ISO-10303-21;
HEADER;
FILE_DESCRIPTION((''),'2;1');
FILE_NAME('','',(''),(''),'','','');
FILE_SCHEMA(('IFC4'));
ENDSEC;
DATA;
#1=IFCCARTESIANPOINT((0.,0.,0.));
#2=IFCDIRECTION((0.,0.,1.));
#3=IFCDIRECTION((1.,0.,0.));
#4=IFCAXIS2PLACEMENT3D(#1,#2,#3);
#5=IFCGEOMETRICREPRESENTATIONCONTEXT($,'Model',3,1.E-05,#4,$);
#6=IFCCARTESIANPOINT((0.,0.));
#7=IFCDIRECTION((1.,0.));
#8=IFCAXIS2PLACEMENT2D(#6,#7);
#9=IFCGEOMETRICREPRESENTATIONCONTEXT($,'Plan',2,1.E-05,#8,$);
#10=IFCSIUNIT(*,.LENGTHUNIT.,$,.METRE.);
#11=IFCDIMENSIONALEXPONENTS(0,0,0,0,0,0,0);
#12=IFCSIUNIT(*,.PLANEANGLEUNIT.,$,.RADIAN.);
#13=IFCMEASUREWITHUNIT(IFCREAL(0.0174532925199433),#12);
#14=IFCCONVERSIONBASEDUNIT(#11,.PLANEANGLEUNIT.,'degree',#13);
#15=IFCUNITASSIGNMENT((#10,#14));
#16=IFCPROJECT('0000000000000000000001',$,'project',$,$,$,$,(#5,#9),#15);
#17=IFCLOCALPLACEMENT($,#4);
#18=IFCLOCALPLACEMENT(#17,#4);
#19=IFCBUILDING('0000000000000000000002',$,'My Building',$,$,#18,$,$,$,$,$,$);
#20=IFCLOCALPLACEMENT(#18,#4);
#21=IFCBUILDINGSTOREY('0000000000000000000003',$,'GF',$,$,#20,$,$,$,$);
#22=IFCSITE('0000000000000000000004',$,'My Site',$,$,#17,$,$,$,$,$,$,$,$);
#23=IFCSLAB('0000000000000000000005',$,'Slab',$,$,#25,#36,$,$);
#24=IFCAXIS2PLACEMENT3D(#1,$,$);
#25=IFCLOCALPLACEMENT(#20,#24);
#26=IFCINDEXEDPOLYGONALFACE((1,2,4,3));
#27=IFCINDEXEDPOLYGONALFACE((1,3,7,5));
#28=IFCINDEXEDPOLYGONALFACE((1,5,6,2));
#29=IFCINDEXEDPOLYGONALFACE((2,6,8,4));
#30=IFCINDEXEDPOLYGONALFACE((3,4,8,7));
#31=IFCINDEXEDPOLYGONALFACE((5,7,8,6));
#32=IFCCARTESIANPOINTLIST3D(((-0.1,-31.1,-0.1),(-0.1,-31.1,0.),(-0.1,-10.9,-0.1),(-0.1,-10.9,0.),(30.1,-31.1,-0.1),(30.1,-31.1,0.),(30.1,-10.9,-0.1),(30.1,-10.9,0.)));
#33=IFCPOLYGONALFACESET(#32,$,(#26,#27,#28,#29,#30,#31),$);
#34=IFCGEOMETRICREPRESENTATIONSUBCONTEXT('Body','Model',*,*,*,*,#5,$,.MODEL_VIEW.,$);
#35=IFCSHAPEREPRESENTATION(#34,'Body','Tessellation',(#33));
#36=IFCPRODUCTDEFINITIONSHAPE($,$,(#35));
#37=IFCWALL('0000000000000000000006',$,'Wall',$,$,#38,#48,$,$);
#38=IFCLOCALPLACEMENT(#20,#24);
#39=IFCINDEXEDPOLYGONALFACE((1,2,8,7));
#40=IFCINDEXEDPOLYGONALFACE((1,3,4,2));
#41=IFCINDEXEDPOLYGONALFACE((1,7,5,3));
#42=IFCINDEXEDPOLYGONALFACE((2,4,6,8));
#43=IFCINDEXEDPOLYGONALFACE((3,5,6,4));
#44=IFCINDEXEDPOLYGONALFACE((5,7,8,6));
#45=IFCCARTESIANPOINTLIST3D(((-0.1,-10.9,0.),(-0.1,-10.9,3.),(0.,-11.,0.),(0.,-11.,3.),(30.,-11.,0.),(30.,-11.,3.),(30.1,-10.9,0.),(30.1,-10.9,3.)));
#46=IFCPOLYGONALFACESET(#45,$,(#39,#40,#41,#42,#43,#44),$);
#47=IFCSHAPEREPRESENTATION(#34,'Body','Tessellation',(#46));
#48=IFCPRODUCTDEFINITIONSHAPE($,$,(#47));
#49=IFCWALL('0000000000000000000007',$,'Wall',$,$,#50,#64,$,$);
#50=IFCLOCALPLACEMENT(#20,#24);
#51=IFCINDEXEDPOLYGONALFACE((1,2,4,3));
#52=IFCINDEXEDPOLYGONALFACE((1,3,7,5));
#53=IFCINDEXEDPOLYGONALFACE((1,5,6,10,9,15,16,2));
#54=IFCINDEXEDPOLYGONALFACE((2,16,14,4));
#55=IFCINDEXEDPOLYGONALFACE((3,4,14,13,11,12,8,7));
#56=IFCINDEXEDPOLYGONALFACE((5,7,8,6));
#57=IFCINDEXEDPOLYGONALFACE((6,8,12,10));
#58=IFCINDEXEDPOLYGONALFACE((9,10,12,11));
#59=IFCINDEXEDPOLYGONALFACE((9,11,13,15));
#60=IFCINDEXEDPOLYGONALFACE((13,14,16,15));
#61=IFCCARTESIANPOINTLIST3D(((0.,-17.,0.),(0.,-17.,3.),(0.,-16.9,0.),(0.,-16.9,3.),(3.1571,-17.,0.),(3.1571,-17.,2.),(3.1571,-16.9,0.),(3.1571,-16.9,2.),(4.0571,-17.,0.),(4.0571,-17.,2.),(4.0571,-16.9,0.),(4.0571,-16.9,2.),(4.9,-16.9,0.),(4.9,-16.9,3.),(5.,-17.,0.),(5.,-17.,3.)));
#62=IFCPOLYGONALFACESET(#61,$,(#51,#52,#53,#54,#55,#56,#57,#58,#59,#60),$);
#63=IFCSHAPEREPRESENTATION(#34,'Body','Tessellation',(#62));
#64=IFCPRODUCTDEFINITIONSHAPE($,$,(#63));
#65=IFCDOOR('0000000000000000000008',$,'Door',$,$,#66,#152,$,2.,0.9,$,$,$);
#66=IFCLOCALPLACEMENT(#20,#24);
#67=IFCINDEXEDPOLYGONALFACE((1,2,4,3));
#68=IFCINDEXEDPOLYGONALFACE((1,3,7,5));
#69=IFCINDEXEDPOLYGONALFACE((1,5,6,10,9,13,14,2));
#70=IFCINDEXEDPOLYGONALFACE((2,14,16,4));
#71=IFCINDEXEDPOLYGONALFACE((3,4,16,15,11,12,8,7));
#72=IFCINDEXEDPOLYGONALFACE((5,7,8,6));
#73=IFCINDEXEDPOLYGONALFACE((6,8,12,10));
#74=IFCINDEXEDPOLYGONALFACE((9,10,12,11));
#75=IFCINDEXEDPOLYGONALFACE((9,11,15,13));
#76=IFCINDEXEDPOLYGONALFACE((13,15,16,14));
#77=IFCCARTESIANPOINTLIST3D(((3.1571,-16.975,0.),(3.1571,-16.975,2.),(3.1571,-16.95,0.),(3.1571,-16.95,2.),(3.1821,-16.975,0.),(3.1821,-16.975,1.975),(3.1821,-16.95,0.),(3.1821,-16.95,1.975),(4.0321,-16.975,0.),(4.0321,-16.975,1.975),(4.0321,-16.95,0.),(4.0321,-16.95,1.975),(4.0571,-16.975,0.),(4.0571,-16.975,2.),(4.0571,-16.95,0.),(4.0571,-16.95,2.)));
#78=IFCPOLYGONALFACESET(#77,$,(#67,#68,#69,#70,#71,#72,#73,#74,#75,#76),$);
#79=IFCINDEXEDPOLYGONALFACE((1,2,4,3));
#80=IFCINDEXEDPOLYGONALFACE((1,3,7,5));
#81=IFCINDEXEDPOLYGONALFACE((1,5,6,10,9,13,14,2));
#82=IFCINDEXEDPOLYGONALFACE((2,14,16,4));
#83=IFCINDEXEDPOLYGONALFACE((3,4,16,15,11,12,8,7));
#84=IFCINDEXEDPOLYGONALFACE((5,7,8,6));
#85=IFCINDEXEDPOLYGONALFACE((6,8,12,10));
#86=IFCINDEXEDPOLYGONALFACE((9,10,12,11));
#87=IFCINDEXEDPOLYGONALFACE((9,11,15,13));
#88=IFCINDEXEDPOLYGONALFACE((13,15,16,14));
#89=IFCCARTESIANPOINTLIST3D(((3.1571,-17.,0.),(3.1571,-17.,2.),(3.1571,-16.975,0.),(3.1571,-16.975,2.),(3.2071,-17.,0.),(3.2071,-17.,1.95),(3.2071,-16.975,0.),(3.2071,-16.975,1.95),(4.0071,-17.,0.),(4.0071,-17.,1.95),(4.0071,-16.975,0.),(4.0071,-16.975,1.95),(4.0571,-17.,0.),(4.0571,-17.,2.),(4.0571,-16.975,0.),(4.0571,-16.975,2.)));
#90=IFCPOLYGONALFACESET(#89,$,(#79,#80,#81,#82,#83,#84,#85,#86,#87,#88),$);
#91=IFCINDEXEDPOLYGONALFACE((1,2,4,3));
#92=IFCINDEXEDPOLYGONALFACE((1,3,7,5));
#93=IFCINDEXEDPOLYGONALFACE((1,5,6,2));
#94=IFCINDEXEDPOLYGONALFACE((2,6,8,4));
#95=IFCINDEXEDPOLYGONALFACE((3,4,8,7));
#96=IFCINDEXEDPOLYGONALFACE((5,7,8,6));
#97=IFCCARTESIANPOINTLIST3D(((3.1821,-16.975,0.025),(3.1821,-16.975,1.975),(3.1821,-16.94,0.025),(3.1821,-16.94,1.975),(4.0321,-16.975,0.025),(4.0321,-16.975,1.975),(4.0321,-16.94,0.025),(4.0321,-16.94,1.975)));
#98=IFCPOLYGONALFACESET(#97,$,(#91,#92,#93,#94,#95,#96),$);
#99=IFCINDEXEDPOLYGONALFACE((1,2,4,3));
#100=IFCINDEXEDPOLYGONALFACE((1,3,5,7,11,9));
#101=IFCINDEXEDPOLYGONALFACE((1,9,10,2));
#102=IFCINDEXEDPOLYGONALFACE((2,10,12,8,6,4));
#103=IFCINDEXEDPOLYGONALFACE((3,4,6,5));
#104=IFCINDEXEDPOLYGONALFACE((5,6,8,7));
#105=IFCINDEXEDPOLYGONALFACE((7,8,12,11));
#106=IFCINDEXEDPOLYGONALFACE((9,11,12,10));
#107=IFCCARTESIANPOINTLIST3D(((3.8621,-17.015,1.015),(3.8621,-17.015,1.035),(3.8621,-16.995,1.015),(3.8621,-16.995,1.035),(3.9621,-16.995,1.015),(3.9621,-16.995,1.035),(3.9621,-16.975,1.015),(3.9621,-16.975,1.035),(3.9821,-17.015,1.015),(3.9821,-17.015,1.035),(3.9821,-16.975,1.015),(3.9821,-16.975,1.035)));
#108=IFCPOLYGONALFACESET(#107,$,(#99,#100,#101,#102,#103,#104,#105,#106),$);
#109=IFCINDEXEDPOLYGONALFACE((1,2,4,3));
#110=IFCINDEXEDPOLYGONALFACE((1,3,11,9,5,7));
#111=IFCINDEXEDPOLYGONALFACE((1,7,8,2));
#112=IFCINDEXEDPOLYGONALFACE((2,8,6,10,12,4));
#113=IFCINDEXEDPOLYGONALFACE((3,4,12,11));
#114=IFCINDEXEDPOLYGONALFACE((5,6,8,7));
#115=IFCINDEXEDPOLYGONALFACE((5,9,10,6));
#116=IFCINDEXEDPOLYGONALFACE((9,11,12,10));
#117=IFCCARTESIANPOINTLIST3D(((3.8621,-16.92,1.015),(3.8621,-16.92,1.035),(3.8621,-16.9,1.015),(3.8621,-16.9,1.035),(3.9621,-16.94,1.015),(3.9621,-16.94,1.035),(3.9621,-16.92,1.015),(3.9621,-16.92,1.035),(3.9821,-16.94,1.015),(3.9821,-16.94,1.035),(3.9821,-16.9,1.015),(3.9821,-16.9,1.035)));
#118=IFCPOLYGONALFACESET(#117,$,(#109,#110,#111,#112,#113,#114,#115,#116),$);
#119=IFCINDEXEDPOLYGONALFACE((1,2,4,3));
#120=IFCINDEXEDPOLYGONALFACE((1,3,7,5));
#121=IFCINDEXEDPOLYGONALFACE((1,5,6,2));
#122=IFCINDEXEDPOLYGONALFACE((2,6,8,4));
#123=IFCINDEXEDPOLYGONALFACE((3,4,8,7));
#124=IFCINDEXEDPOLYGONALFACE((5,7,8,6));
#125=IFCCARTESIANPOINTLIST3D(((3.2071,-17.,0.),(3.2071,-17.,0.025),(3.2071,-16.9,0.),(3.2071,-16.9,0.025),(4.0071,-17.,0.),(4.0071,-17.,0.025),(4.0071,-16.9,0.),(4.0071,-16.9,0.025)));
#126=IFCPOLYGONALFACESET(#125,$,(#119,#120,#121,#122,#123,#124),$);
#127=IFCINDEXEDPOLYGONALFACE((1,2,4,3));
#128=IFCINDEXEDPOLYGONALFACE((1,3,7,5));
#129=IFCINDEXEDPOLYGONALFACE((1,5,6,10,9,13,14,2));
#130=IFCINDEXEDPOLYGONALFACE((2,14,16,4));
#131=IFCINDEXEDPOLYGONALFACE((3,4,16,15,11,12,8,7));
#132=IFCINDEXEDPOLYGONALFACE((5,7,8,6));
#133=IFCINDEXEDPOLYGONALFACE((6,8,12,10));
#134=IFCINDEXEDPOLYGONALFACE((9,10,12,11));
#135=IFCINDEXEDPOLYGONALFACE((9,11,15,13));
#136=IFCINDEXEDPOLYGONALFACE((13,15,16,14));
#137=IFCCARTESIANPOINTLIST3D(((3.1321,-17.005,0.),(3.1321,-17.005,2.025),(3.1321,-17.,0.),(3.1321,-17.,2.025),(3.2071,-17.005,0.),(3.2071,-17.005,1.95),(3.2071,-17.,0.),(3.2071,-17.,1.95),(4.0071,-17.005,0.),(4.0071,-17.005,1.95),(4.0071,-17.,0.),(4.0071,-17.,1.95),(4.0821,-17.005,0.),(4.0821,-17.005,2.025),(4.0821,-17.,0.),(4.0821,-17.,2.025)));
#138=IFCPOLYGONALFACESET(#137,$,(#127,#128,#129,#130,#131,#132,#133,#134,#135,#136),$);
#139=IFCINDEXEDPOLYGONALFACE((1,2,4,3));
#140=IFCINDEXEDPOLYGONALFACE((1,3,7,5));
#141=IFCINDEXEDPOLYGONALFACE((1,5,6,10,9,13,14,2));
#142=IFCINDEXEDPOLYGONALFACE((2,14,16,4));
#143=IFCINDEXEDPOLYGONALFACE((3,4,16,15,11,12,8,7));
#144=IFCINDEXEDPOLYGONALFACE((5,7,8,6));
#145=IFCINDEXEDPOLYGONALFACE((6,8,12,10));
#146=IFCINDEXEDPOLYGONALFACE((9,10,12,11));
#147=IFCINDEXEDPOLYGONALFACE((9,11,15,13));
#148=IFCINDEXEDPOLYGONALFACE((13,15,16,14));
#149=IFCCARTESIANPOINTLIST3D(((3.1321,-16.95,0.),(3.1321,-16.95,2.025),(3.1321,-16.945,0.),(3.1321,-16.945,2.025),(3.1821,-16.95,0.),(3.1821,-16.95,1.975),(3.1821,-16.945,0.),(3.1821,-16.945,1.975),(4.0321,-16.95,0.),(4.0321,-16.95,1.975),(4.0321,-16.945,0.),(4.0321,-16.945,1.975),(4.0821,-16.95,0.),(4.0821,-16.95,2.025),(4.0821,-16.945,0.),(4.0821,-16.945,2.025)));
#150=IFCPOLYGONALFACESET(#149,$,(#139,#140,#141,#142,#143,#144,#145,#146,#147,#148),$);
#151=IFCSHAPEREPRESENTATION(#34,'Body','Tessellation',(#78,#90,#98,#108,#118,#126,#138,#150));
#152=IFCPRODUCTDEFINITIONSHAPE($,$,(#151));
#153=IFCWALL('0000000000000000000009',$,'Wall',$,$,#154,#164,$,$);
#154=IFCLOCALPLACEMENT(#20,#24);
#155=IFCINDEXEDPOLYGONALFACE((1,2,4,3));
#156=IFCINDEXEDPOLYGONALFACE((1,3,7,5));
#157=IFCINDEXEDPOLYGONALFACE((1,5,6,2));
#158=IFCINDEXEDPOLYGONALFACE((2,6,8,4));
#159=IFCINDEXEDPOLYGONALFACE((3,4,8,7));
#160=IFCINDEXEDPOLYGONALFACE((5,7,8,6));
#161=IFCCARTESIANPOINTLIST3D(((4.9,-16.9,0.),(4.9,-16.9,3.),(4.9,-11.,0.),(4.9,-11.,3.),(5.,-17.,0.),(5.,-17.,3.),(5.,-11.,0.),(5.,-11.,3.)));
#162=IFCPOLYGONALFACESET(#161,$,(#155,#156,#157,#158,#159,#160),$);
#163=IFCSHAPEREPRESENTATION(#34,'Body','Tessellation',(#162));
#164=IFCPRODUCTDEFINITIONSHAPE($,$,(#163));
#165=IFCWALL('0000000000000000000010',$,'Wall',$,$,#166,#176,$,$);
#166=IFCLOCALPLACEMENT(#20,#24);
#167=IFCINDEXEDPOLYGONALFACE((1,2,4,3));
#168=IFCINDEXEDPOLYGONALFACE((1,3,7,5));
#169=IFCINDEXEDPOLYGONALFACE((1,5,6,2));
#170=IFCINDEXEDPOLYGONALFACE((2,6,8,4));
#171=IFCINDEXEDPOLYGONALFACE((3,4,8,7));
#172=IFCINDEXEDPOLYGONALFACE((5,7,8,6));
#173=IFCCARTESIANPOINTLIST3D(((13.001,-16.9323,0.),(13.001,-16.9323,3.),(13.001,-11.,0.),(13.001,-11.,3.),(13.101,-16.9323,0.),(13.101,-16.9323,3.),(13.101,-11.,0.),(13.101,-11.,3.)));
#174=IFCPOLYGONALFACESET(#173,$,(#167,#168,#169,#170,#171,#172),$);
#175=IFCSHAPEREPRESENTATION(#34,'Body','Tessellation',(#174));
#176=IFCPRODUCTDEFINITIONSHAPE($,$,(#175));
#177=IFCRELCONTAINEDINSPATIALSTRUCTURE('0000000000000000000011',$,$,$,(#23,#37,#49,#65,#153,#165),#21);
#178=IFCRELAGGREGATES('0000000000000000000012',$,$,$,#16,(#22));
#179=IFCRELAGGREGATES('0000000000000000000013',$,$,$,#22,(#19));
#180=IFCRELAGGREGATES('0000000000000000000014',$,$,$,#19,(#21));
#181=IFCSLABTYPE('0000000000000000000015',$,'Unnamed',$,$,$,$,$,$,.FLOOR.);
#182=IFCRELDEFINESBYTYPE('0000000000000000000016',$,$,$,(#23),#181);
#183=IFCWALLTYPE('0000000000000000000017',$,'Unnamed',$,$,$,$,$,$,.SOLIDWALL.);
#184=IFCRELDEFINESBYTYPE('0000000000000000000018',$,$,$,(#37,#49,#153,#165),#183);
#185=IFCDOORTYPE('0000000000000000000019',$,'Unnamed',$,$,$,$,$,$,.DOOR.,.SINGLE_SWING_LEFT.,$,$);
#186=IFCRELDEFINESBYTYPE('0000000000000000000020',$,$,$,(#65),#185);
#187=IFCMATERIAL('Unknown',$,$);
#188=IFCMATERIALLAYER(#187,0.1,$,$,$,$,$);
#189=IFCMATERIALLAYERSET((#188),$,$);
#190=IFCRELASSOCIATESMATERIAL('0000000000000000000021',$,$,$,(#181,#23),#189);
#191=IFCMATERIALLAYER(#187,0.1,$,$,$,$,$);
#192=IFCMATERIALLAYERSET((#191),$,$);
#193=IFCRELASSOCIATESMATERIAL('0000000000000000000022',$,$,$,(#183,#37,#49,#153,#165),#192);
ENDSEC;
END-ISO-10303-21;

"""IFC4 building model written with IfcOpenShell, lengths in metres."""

from ifc_helpers import new_model, entity, si_unit, converted_unit, frame, origin_with_axes, origin_2d_with_axis, place, context, subcontext, project, spatial, line, indexed_curve, outline, extrude, shape, source, transform, mapped, material, layer, layer_set, layer_usage, type_object, type_shapes, element, fill, save


model = new_model("IFC4")

# Units and contexts
model_context = context("Model", 3, precision=1e-05, world=origin_with_axes())
plan_context = context("Plan", 2, precision=1e-05, world=origin_2d_with_axis())
body_context_1 = subcontext(model_context, "Body", "Model", "MODEL_VIEW")
body_context_2 = subcontext(plan_context, "Body", "Plan", "PLAN_VIEW")
ifc_project = project(units=[si_unit("LENGTHUNIT", "METRE"), converted_unit("PLANEANGLEUNIT", "degree", entity("IfcReal", 0.0174532925199433), si_unit("PLANEANGLEUNIT", "RADIAN"), dimensions=[0, 0, 0, 0, 0, 0, 0])], contexts=[model_context, plan_context])

# Site, building, storey
site_placement = place(None, origin_with_axes())
site = spatial("IfcSite", under=ifc_project, at=site_placement, Name="My Site")
building_placement = place(site_placement, origin_with_axes())
building = spatial("IfcBuilding", under=site, at=building_placement, Name="My Building")
storey_placement = place(building_placement, origin_with_axes())
storey = spatial("IfcBuildingStorey", under=building, at=storey_placement, Name="GF")

# Slab
ifc_material = material(Name="Unknown")
ifc_layer_1 = layer(ifc_material, 0.1)
ifc_layer_set_1 = layer_set([ifc_layer_1])
ifc_layer_usage_1 = layer_usage(ifc_layer_set_1, "AXIS3", "POSITIVE", -0.1)
slab_type = type_object("IfcSlabType", Name="Unnamed", PredefinedType="FLOOR", material=ifc_layer_set_1)
slab_placement = place(storey_placement, frame((-0.1, -10.9, 0.0), z_axis=(0.0, 0.0, 1.0), x_axis=(1.0, 0.0, 0.0)))
element("IfcSlab", 1, at=slab_placement, inside=storey, type_object=slab_type, material=ifc_layer_usage_1, Name="Slab", context=body_context_1, shape_type="SweptSolid", body=[
    extrude(outline(indexed_curve([(0.0, 0.0), (30.2, 0.0), (30.2, -20.2), (0.0, -20.2), (0.0, 0.0)])), frame((0.0, 0.0, -0.1), z_axis=(0.0, 0.0, 1.0), x_axis=(1.0, 0.0, 0.0)), (0.0, 0.0, 1.0), 0.1),
])

# Wall
ifc_layer_2 = layer(ifc_material, 0.1)
ifc_layer_set_2 = layer_set([ifc_layer_2])
ifc_layer_usage_2 = layer_usage(ifc_layer_set_2, "AXIS2", "POSITIVE", 0.0)
wall_type = type_object("IfcWallType", Name="Unnamed", PredefinedType="SOLIDWALL", material=ifc_layer_set_2)
wall_1_placement = place(storey_placement, frame((0.0, -11.0, 0.0), z_axis=(0.0, 0.0, 1.0), x_axis=(1.0, 0.0, 0.0)))
element("IfcWall", 2, at=wall_1_placement, inside=storey, type_object=wall_type, material=ifc_layer_usage_2, Name="Wall", context=body_context_1, shape_type="SweptSolid", body=[
    extrude(outline(indexed_curve([(0.0, 0.0), (-0.1, 0.1), (30.1, 0.1), (30.0, 0.0)], segments=[line(1, 2, 3, 4, 1)])), origin_with_axes(), (0.0, 0.0, 1.0), 3.0),
])

# Wall, opening, door
ifc_layer_usage_3 = layer_usage(ifc_layer_set_2, "AXIS2", "POSITIVE", 0.0)
wall_2_placement = place(storey_placement, frame((0.0, -17.0, 0.0), z_axis=(0.0, 0.0, 1.0), x_axis=(1.0, 0.0, 0.0)))
wall_2 = element("IfcWall", 3, at=wall_2_placement, inside=storey, type_object=wall_type, material=ifc_layer_usage_3, Name="Wall", context=body_context_1, shape_type="SweptSolid", body=[
    extrude(outline(indexed_curve([(0.0, 0.0), (0.0, 0.1), (4.9, 0.1), (5.0, 0.0)], segments=[line(1, 2, 3, 4, 1)])), origin_with_axes(), (0.0, 0.0, 1.0), 3.0),
])
shared_shape_1 = source(origin_with_axes(), body_context_1, "Body", "SweptSolid", [
    extrude(outline(indexed_curve([(0.0, 0.0), (0.9, 0.0), (0.9, 2.0), (0.0, 2.0)], segments=[line(1, 2, 3, 4, 1)])), frame((0.0, -0.6, 0.0), z_axis=(0.0, -1.0, 0.0), x_axis=(1.0, 0.0, 0.0)), (0.0, 0.0, -1.0), 1.2),
])
opening_1_placement = place(wall_2_placement, frame((3.1571, 0.0, 0.0), z_axis=(0.0, 0.0, 1.0), x_axis=(1.0, 0.0, 0.0)))
opening_1 = element("IfcOpeningElement", 4, at=opening_1_placement, cuts=wall_2, PredefinedType="OPENING", context=body_context_1, shape_type="MappedRepresentation", body=[
    mapped(shared_shape_1, transform((0.0, 0.0, 0.0), x_axis=(1.0, 0.0, 0.0), y_axis=(0.0, 1.0, 0.0), z_axis=(0.0, 0.0, 1.0), scale=1.0)),
])
door_type = type_object("IfcDoorType", Name="Unnamed", OperationType="SINGLE_SWING_LEFT", PredefinedType="DOOR")
shared_shape_2 = source(origin_with_axes(), body_context_1, "Body", "SweptSolid", [
    extrude(outline(indexed_curve([(0.0, 0.0), (0.0, 2.0), (0.9, 2.0), (0.9, 0.0), (0.875, 0.0), (0.875, 1.975), (0.025, 1.975), (0.025, 0.0)], segments=[line(1, 2, 3, 4, 5, 6, 7, 8, 1)])), frame((0.0, 0.025, 0.0), z_axis=(0.0, -1.0, 0.0), x_axis=(1.0, 0.0, 0.0)), (0.0, 0.0, -1.0), 0.025),
    extrude(outline(indexed_curve([(0.0, 0.0), (0.0, 2.0), (0.9, 2.0), (0.9, 0.0), (0.85, 0.0), (0.85, 1.95), (0.05, 1.95), (0.05, 0.0)], segments=[line(1, 2, 3, 4, 5, 6, 7, 8, 1)])), frame((0.0, 0.0, 0.0), z_axis=(0.0, -1.0, 0.0), x_axis=(1.0, 0.0, 0.0)), (0.0, 0.0, -1.0), 0.025),
    extrude(outline(indexed_curve([(0.0, 0.0), (0.85, 0.0), (0.85, 0.035), (0.0, 0.035)], segments=[line(1, 2, 3, 4, 1)])), frame((0.025, 0.025, 0.025), z_axis=(0.0, 0.0, 1.0), x_axis=(1.0, 0.0, 0.0)), (0.0, 0.0, 1.0), 1.95),
    extrude(outline(indexed_curve([(0.0, 0.0), (0.0, -0.04), (-0.12, -0.04), (-0.12, -0.02), (-0.02, -0.02), (-0.02, 0.0)], segments=[line(1, 2, 3, 4, 5, 6, 1)])), frame((0.825, 0.025, 1.015), z_axis=(0.0, 0.0, 1.0), x_axis=(1.0, 0.0, 0.0)), (0.0, 0.0, 1.0), 0.02),
    extrude(outline(indexed_curve([(0.0, 0.0), (0.0, 0.04), (-0.12, 0.04), (-0.12, 0.02), (-0.02, 0.02), (-0.02, 0.0)], segments=[line(1, 2, 3, 4, 5, 6, 1)])), frame((0.825, 0.06, 1.015), z_axis=(0.0, 0.0, 1.0), x_axis=(1.0, 0.0, 0.0)), (0.0, 0.0, 1.0), 0.02),
    extrude(outline(indexed_curve([(0.0, 0.0), (0.8, 0.0), (0.8, 0.1), (0.0, 0.1)], segments=[line(1, 2, 3, 4, 1)])), frame((0.05, 0.0, 0.0), z_axis=(0.0, 0.0, 1.0), x_axis=(1.0, 0.0, 0.0)), (0.0, 0.0, 1.0), 0.025),
    extrude(outline(indexed_curve([(0.0, 0.0), (0.0, 2.025), (0.95, 2.025), (0.95, 0.0), (0.875, 0.0), (0.875, 1.95), (0.075, 1.95), (0.075, 0.0)], segments=[line(1, 2, 3, 4, 5, 6, 7, 8, 1)])), frame((-0.025, -0.005, 0.0), z_axis=(0.0, -1.0, 0.0), x_axis=(1.0, 0.0, 0.0)), (0.0, 0.0, -1.0), 0.005),
    extrude(outline(indexed_curve([(0.0, 0.0), (0.0, 2.025), (0.95, 2.025), (0.95, 0.0), (0.9, 0.0), (0.9, 1.975), (0.05, 1.975), (0.05, 0.0)], segments=[line(1, 2, 3, 4, 5, 6, 7, 8, 1)])), frame((-0.025, 0.05, 0.0), z_axis=(0.0, -1.0, 0.0), x_axis=(1.0, 0.0, 0.0)), (0.0, 0.0, -1.0), 0.005),
])
shared_shape_3 = source(origin_with_axes(), body_context_2, "Body", "Curve2D", [
    entity("IfcIndexedPolyCurve", entity("IfcCartesianPointList2D", [[0.0, 0.0], [0.0, 0.05], [0.025, 0.05], [0.025, 0.025], [0.05, 0.025], [0.05, 0.0]]), [entity("IfcLineIndex", [1, 2, 3, 4, 5, 6, 1])]),
    entity("IfcIndexedPolyCurve", entity("IfcCartesianPointList2D", [[0.9, 0.0], [0.9, 0.05], [0.875, 0.05], [0.875, 0.025], [0.85, 0.025], [0.85, 0.0]]), [entity("IfcLineIndex", [1, 2, 3, 4, 5, 6, 1])]),
    entity("IfcTrimmedCurve", entity("IfcEllipse", entity("IfcAxis2Placement2D", entity("IfcCartesianPoint", [0.06, 0.05]), entity("IfcDirection", [1.0, 0.0])), 0.815, 0.85), [entity("IfcCartesianPoint", [0.875, 0.05])], [entity("IfcCartesianPoint", [0.06, 0.9])], True, "CARTESIAN"),
    entity("IfcIndexedPolyCurve", entity("IfcCartesianPointList2D", [[0.025, 0.05], [0.06, 0.05], [0.06, 0.9], [0.025, 0.9]]), [entity("IfcLineIndex", [1, 2, 3, 4, 1])]),
])
type_shapes(door_type, [shared_shape_2, shared_shape_3])
door_1_placement = place(opening_1_placement, origin_with_axes())
door_1 = element("IfcDoor", 5, at=door_1_placement, inside=storey, type_object=door_type, Name="Door", OverallHeight=2.0, OverallWidth=0.9, shapes=[
    shape(body_context_1, "Body", "MappedRepresentation", [mapped(shared_shape_2, transform((0.0, 0.0, 0.0), x_axis=(1.0, 0.0, 0.0), y_axis=(0.0, 1.0, 0.0), z_axis=(0.0, 0.0, 1.0), scale=1.0))]),
    shape(body_context_2, "Body", "MappedRepresentation", [mapped(shared_shape_3, transform((0.0, 0.0, 0.0), x_axis=(1.0, 0.0, 0.0), y_axis=(0.0, 1.0, 0.0), z_axis=(0.0, 0.0, 1.0), scale=1.0))]),
])
fill(opening_1, door_1)

# Wall
ifc_layer_usage_4 = layer_usage(ifc_layer_set_2, "AXIS2", "POSITIVE", 0.0)
wall_3_placement = place(storey_placement, frame((5.0, -17.0, 0.0), z_axis=(0.0, 0.0, 1.0), x_axis=(0.0, 1.0, 0.0)))
element("IfcWall", 6, at=wall_3_placement, inside=storey, type_object=wall_type, material=ifc_layer_usage_4, Name="Wall", context=body_context_1, shape_type="SweptSolid", body=[
    extrude(outline(indexed_curve([(0.0, 0.0), (0.1, 0.1), (6.0, 0.1), (6.0, 0.0)], segments=[line(1, 2, 3, 4, 1)])), origin_with_axes(), (0.0, 0.0, 1.0), 3.0),
])

# Wall
ifc_layer_usage_5 = layer_usage(ifc_layer_set_2, "AXIS2", "POSITIVE", 0.0)
wall_4_placement = place(storey_placement, frame((13.101, -16.9323, 0.0), z_axis=(0.0, 0.0, 1.0), x_axis=(0.0, 1.0, 0.0)))
element("IfcWall", 7, at=wall_4_placement, inside=storey, type_object=wall_type, material=ifc_layer_usage_5, Name="Wall", context=body_context_1, shape_type="SweptSolid", body=[
    extrude(outline(indexed_curve([(0.0, 0.0), (0.0, 0.1), (5.9323, 0.1), (5.9323, 0.0)], segments=[line(1, 2, 3, 4, 1)])), origin_with_axes(), (0.0, 0.0, 1.0), 3.0),
])

save(model, "model.ifc")
